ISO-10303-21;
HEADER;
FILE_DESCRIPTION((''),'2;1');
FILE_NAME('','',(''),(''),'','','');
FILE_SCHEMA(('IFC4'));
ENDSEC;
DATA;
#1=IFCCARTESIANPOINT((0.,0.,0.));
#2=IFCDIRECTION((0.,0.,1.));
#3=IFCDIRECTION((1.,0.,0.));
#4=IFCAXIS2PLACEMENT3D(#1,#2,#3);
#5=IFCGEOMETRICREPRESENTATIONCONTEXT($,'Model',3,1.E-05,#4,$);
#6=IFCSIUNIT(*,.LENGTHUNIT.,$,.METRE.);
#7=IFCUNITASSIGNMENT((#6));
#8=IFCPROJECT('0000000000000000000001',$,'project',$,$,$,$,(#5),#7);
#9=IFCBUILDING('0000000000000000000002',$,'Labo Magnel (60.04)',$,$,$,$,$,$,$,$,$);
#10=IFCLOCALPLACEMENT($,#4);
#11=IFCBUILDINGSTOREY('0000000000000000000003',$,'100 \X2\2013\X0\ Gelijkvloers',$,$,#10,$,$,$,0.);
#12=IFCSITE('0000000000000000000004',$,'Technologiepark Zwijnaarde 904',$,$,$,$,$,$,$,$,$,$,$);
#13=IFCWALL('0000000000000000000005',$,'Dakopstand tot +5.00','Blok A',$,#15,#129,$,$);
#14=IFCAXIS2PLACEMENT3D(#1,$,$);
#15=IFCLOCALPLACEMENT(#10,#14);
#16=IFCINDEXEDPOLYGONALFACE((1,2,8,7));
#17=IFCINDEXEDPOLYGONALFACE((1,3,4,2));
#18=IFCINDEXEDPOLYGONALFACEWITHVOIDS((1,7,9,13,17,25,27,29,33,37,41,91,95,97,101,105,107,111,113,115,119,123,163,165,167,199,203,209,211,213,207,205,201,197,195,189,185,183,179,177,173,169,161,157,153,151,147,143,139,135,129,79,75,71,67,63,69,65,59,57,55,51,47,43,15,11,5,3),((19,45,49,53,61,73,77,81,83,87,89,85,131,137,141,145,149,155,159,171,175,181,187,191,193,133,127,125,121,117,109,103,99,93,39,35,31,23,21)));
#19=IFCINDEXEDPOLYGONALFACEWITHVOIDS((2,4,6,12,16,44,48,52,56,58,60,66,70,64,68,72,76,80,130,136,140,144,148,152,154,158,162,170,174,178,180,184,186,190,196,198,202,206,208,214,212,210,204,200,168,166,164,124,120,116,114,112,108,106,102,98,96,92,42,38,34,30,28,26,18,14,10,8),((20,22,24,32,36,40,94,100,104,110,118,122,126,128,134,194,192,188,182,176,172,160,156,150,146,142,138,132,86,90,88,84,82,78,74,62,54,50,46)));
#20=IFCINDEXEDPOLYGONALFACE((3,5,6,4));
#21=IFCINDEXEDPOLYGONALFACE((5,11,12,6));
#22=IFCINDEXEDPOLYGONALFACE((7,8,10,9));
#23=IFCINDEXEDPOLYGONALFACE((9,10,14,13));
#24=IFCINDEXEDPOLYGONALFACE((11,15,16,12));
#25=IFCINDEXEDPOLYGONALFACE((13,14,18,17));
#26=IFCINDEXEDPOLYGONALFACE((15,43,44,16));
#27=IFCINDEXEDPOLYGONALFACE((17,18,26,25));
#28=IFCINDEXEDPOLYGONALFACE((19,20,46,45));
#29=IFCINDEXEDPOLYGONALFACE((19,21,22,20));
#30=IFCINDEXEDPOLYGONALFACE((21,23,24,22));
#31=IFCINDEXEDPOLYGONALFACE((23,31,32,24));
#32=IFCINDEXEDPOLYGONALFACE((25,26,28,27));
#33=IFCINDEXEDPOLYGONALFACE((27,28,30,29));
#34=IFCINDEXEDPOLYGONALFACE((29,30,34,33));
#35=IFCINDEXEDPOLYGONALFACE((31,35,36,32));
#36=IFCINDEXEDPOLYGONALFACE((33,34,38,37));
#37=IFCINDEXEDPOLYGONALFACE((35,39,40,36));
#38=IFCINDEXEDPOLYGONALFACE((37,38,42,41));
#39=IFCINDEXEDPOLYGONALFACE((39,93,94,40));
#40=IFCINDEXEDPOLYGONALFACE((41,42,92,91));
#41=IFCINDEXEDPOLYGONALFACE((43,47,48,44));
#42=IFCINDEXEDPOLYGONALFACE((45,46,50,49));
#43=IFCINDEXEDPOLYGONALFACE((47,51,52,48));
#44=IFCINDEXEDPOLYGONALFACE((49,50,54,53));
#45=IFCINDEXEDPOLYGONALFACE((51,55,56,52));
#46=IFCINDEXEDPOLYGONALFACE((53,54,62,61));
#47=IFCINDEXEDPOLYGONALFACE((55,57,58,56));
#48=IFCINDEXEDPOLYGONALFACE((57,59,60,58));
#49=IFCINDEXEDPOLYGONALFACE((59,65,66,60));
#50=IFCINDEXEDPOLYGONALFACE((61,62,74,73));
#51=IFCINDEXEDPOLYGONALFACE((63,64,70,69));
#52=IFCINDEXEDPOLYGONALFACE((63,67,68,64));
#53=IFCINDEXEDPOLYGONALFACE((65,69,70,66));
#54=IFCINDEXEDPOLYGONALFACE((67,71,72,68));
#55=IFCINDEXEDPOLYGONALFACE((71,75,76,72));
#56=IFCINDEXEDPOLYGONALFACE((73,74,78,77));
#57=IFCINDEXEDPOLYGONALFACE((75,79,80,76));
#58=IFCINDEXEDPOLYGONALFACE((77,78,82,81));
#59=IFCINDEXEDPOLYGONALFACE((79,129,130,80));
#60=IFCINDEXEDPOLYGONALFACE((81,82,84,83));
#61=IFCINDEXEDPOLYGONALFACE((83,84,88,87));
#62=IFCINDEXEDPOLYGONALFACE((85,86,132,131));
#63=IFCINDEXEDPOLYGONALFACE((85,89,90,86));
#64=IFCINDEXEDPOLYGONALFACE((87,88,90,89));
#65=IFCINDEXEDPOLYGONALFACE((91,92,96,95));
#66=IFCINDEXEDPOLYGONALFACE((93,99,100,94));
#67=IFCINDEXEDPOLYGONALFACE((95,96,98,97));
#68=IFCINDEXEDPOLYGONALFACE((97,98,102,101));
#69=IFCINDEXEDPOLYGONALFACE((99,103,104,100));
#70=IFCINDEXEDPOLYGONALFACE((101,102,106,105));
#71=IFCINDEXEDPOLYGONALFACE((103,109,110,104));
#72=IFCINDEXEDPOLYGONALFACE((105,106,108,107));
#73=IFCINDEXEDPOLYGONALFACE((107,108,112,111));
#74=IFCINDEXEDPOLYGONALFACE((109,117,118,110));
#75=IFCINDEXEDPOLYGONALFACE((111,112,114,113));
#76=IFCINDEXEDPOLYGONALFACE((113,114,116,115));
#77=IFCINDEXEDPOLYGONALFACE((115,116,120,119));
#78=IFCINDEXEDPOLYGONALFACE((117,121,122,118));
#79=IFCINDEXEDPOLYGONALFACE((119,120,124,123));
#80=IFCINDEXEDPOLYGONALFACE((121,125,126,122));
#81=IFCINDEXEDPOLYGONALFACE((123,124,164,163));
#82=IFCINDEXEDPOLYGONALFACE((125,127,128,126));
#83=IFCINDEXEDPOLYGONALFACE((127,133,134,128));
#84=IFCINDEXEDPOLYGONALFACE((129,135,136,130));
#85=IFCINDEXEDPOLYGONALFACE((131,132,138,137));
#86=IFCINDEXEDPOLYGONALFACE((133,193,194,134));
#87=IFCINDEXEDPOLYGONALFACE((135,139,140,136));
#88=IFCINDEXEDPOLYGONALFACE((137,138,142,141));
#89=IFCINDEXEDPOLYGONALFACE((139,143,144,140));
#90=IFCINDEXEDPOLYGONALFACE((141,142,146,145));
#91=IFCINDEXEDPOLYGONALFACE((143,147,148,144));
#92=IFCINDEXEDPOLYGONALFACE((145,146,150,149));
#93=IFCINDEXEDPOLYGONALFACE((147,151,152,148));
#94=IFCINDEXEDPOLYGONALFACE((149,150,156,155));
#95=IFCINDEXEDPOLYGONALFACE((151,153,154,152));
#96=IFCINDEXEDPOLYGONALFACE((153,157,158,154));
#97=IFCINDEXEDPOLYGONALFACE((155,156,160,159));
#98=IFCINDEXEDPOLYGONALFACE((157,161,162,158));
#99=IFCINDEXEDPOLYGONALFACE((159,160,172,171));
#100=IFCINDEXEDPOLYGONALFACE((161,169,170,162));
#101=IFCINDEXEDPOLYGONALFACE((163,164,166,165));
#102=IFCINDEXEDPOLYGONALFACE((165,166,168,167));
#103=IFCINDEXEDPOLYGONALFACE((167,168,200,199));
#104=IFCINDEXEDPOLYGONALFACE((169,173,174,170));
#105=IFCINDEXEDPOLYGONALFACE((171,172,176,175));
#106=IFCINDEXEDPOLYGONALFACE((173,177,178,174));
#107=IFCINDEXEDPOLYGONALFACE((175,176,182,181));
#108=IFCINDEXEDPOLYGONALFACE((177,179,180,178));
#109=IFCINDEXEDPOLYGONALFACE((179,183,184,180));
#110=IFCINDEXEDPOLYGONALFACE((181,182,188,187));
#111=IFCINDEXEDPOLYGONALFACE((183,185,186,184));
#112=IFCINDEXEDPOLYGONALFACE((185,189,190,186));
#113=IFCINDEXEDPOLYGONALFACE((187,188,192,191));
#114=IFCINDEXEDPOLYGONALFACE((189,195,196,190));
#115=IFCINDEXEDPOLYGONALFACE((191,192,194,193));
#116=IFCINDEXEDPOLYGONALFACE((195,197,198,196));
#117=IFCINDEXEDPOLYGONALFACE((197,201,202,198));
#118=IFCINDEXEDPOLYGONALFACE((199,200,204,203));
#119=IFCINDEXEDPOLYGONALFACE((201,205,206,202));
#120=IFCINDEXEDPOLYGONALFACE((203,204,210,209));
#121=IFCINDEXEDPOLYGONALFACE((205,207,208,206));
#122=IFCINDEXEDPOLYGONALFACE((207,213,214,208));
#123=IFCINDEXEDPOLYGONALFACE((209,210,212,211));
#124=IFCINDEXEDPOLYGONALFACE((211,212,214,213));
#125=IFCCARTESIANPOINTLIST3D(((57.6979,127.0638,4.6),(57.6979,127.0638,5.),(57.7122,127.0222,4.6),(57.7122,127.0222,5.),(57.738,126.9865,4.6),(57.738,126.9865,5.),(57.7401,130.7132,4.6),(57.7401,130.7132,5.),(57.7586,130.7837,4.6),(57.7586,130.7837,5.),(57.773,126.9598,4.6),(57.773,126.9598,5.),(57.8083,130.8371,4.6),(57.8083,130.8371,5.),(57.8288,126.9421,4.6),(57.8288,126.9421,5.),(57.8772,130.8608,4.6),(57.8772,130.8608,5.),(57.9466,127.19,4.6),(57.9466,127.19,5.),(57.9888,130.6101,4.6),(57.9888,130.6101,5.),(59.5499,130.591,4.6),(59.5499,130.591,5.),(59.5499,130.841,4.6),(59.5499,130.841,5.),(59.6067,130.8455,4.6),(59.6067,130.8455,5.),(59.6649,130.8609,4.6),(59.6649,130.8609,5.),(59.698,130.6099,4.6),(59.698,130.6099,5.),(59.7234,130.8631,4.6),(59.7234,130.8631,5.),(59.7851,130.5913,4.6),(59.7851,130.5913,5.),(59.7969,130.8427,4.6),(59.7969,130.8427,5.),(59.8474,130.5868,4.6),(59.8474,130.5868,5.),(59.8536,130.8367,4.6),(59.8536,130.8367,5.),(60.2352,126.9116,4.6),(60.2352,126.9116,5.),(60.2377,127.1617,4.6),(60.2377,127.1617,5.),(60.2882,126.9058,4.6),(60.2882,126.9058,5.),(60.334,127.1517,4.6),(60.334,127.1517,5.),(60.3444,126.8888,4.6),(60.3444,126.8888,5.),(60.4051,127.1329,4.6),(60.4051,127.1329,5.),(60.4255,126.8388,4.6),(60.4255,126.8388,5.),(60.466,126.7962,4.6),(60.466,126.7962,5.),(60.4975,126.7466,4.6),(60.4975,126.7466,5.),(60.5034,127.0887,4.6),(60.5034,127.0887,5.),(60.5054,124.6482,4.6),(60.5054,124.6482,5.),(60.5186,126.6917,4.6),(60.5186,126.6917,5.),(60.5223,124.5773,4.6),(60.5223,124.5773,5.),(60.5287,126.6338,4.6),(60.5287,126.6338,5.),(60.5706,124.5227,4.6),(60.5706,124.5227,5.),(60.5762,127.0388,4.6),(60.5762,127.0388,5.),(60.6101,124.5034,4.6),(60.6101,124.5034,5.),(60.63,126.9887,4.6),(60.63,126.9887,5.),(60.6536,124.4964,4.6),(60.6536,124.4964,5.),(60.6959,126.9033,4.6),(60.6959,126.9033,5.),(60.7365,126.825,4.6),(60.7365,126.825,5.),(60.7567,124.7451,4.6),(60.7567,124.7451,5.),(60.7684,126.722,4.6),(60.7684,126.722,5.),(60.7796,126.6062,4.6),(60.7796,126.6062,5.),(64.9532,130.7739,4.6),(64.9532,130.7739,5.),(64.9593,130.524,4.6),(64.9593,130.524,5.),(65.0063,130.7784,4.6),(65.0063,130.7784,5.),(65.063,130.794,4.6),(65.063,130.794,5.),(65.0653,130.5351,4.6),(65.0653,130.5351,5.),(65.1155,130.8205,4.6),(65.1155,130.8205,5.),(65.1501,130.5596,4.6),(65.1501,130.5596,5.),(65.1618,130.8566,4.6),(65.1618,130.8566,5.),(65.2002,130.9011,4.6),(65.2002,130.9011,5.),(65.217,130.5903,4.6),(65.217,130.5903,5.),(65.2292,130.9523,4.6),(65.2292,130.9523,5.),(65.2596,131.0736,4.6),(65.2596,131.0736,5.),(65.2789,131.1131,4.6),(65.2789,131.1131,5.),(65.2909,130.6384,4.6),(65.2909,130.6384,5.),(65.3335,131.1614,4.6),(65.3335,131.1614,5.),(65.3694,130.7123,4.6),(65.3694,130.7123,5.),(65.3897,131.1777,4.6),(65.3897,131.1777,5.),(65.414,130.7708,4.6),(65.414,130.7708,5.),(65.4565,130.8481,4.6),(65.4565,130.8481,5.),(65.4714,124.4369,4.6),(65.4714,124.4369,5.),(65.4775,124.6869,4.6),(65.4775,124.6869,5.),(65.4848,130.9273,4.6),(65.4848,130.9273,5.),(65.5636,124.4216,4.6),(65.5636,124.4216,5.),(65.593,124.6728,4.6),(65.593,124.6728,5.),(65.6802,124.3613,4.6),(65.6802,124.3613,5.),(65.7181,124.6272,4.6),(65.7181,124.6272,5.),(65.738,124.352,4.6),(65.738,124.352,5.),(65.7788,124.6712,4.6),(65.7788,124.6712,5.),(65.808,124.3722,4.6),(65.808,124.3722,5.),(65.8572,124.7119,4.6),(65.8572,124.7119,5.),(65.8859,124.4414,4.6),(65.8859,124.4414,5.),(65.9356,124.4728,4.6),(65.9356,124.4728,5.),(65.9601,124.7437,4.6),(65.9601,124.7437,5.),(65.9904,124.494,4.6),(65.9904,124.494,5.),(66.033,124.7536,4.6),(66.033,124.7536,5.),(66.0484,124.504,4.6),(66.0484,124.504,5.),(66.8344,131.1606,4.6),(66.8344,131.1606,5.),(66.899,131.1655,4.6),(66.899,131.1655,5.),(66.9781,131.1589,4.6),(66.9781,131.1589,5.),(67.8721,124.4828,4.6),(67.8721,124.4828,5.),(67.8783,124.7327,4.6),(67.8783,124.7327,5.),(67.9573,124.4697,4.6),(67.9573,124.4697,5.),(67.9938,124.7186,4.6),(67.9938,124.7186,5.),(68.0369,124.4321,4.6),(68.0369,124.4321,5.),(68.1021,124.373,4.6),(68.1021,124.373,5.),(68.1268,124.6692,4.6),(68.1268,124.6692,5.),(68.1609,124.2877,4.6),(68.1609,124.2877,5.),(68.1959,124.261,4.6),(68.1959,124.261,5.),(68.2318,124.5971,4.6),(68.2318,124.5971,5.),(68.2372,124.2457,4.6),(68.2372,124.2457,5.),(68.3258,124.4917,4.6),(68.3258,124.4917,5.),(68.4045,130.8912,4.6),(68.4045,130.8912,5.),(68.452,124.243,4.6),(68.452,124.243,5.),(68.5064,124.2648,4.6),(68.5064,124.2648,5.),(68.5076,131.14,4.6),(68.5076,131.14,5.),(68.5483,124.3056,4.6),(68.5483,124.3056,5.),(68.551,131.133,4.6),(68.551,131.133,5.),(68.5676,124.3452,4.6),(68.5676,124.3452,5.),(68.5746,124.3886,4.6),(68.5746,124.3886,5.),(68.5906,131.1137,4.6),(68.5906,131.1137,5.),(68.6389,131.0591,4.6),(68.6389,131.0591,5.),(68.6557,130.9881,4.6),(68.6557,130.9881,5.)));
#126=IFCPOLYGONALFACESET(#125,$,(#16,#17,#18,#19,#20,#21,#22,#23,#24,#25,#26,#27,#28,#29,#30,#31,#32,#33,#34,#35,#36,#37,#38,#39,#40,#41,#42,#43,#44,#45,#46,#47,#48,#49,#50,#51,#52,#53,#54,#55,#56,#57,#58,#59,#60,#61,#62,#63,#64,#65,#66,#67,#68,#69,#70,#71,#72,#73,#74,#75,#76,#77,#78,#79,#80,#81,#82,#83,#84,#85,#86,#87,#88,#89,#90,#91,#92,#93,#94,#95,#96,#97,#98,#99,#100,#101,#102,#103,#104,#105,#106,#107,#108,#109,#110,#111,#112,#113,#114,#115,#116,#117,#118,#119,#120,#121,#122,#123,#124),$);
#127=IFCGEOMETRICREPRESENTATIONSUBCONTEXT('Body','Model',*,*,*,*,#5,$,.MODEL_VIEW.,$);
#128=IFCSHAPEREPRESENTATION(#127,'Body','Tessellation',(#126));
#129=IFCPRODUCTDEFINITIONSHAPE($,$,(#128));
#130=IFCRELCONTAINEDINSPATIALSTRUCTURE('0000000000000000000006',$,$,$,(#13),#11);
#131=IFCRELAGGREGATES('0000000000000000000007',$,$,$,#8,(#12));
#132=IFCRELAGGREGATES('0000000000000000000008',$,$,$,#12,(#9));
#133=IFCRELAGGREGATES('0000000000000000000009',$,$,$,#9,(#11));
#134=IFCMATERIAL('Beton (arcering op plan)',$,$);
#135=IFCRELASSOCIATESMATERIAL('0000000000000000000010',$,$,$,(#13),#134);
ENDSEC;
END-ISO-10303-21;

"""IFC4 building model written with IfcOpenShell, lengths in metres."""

from ifc_helpers import new_model, si_unit, frame, origin, origin_with_axes, place, context, subcontext, project, spatial, polyline, outline, extrude, material, element, save


model = new_model("IFC4")

# Units and contexts
model_context = context("Model", 3, precision=1e-05, world=origin_with_axes())
body_context = subcontext(model_context, "Body", "Model", "MODEL_VIEW")
ifc_project = project(units=[si_unit("LENGTHUNIT", "METRE")], contexts=[model_context])

# Site, building, storey
site = spatial("IfcSite", under=ifc_project, Name="Technologiepark Zwijnaarde 904")
building = spatial("IfcBuilding", under=site, Name="Labo Magnel (60.04)")
storey_placement = place(None, origin_with_axes())
storey = spatial("IfcBuildingStorey", under=building, at=storey_placement, Name="100 – Gelijkvloers", Elevation=0.0)

# Shared definitions
ifc_material_1 = material(Name="Beton (arcering op plan)")

# Wall
wall_1_placement = place(storey_placement, frame((0.0, 0.0, 4.6), z_axis=(0.0, 0.0, 1.0), x_axis=(1.0, 0.0, 0.0)))
element("IfcWall", 1, at=wall_1_placement, inside=storey, material=ifc_material_1, Name="Dakopstand tot +5.00", Description="Blok A", context=body_context, shape_type="SweptSolid", body=[
    extrude(outline(polyline([(59.6649, 130.8609), (59.7234, 130.8631), (59.7969, 130.8427), (59.8536, 130.8367), (64.9532, 130.7739), (65.0063, 130.7784), (65.063, 130.794), (65.1155, 130.8205), (65.1618, 130.8566), (65.2002, 130.9011), (65.2292, 130.9523), (65.2596, 131.0736), (65.2789, 131.1131), (65.3335, 131.1614), (65.3897, 131.1777), (66.8344, 131.1606), (66.899, 131.1655), (66.9781, 131.1589), (68.5076, 131.14), (68.551, 131.133), (68.5906, 131.1137), (68.6389, 131.0591), (68.6557, 130.9881), (68.5746, 124.3886), (68.5676, 124.3452), (68.5483, 124.3056), (68.5064, 124.2648), (68.452, 124.243), (68.2372, 124.2457), (68.1959, 124.261), (68.1609, 124.2877), (68.1021, 124.373), (68.0369, 124.4321), (67.9573, 124.4697), (67.8721, 124.4828), (66.0484, 124.504), (65.9904, 124.494), (65.9356, 124.4728), (65.8859, 124.4414), (65.808, 124.3722), (65.738, 124.352), (65.6802, 124.3613), (65.5636, 124.4216), (65.4714, 124.4369), (60.6536, 124.4964), (60.6101, 124.5034), (60.5706, 124.5227), (60.5223, 124.5773), (60.5054, 124.6482), (60.5287, 126.6338), (60.5186, 126.6917), (60.4975, 126.7466), (60.466, 126.7962), (60.4255, 126.8388), (60.3444, 126.8888), (60.2882, 126.9058), (60.2352, 126.9116), (57.8288, 126.9421), (57.773, 126.9598), (57.738, 126.9865), (57.7122, 127.0222), (57.6979, 127.0638), (57.7401, 130.7132), (57.7586, 130.7837), (57.8083, 130.8371), (57.8772, 130.8608), (59.5499, 130.841), (59.6067, 130.8455), (59.6649, 130.8609)]), holes=[polyline([(60.2377, 127.1617), (60.334, 127.1517), (60.4051, 127.1329), (60.5034, 127.0887), (60.5762, 127.0388), (60.63, 126.9887), (60.6959, 126.9033), (60.7365, 126.825), (60.7684, 126.722), (60.7796, 126.6062), (60.7567, 124.7451), (65.4775, 124.6869), (65.593, 124.6728), (65.7181, 124.6272), (65.7788, 124.6712), (65.8572, 124.7119), (65.9601, 124.7437), (66.033, 124.7536), (67.8783, 124.7327), (67.9938, 124.7186), (68.1268, 124.6692), (68.2318, 124.5971), (68.3258, 124.4917), (68.4045, 130.8912), (65.4848, 130.9273), (65.4565, 130.8481), (65.414, 130.7708), (65.3694, 130.7123), (65.2909, 130.6384), (65.217, 130.5903), (65.1501, 130.5596), (65.0653, 130.5351), (64.9593, 130.524), (59.8474, 130.5868), (59.7851, 130.5913), (59.698, 130.6099), (59.5499, 130.591), (57.9888, 130.6101), (57.9466, 127.19), (60.2377, 127.1617)])]), origin(), (0.0, 0.0, 1.0), 0.4),
])

save(model, "model.ifc")
